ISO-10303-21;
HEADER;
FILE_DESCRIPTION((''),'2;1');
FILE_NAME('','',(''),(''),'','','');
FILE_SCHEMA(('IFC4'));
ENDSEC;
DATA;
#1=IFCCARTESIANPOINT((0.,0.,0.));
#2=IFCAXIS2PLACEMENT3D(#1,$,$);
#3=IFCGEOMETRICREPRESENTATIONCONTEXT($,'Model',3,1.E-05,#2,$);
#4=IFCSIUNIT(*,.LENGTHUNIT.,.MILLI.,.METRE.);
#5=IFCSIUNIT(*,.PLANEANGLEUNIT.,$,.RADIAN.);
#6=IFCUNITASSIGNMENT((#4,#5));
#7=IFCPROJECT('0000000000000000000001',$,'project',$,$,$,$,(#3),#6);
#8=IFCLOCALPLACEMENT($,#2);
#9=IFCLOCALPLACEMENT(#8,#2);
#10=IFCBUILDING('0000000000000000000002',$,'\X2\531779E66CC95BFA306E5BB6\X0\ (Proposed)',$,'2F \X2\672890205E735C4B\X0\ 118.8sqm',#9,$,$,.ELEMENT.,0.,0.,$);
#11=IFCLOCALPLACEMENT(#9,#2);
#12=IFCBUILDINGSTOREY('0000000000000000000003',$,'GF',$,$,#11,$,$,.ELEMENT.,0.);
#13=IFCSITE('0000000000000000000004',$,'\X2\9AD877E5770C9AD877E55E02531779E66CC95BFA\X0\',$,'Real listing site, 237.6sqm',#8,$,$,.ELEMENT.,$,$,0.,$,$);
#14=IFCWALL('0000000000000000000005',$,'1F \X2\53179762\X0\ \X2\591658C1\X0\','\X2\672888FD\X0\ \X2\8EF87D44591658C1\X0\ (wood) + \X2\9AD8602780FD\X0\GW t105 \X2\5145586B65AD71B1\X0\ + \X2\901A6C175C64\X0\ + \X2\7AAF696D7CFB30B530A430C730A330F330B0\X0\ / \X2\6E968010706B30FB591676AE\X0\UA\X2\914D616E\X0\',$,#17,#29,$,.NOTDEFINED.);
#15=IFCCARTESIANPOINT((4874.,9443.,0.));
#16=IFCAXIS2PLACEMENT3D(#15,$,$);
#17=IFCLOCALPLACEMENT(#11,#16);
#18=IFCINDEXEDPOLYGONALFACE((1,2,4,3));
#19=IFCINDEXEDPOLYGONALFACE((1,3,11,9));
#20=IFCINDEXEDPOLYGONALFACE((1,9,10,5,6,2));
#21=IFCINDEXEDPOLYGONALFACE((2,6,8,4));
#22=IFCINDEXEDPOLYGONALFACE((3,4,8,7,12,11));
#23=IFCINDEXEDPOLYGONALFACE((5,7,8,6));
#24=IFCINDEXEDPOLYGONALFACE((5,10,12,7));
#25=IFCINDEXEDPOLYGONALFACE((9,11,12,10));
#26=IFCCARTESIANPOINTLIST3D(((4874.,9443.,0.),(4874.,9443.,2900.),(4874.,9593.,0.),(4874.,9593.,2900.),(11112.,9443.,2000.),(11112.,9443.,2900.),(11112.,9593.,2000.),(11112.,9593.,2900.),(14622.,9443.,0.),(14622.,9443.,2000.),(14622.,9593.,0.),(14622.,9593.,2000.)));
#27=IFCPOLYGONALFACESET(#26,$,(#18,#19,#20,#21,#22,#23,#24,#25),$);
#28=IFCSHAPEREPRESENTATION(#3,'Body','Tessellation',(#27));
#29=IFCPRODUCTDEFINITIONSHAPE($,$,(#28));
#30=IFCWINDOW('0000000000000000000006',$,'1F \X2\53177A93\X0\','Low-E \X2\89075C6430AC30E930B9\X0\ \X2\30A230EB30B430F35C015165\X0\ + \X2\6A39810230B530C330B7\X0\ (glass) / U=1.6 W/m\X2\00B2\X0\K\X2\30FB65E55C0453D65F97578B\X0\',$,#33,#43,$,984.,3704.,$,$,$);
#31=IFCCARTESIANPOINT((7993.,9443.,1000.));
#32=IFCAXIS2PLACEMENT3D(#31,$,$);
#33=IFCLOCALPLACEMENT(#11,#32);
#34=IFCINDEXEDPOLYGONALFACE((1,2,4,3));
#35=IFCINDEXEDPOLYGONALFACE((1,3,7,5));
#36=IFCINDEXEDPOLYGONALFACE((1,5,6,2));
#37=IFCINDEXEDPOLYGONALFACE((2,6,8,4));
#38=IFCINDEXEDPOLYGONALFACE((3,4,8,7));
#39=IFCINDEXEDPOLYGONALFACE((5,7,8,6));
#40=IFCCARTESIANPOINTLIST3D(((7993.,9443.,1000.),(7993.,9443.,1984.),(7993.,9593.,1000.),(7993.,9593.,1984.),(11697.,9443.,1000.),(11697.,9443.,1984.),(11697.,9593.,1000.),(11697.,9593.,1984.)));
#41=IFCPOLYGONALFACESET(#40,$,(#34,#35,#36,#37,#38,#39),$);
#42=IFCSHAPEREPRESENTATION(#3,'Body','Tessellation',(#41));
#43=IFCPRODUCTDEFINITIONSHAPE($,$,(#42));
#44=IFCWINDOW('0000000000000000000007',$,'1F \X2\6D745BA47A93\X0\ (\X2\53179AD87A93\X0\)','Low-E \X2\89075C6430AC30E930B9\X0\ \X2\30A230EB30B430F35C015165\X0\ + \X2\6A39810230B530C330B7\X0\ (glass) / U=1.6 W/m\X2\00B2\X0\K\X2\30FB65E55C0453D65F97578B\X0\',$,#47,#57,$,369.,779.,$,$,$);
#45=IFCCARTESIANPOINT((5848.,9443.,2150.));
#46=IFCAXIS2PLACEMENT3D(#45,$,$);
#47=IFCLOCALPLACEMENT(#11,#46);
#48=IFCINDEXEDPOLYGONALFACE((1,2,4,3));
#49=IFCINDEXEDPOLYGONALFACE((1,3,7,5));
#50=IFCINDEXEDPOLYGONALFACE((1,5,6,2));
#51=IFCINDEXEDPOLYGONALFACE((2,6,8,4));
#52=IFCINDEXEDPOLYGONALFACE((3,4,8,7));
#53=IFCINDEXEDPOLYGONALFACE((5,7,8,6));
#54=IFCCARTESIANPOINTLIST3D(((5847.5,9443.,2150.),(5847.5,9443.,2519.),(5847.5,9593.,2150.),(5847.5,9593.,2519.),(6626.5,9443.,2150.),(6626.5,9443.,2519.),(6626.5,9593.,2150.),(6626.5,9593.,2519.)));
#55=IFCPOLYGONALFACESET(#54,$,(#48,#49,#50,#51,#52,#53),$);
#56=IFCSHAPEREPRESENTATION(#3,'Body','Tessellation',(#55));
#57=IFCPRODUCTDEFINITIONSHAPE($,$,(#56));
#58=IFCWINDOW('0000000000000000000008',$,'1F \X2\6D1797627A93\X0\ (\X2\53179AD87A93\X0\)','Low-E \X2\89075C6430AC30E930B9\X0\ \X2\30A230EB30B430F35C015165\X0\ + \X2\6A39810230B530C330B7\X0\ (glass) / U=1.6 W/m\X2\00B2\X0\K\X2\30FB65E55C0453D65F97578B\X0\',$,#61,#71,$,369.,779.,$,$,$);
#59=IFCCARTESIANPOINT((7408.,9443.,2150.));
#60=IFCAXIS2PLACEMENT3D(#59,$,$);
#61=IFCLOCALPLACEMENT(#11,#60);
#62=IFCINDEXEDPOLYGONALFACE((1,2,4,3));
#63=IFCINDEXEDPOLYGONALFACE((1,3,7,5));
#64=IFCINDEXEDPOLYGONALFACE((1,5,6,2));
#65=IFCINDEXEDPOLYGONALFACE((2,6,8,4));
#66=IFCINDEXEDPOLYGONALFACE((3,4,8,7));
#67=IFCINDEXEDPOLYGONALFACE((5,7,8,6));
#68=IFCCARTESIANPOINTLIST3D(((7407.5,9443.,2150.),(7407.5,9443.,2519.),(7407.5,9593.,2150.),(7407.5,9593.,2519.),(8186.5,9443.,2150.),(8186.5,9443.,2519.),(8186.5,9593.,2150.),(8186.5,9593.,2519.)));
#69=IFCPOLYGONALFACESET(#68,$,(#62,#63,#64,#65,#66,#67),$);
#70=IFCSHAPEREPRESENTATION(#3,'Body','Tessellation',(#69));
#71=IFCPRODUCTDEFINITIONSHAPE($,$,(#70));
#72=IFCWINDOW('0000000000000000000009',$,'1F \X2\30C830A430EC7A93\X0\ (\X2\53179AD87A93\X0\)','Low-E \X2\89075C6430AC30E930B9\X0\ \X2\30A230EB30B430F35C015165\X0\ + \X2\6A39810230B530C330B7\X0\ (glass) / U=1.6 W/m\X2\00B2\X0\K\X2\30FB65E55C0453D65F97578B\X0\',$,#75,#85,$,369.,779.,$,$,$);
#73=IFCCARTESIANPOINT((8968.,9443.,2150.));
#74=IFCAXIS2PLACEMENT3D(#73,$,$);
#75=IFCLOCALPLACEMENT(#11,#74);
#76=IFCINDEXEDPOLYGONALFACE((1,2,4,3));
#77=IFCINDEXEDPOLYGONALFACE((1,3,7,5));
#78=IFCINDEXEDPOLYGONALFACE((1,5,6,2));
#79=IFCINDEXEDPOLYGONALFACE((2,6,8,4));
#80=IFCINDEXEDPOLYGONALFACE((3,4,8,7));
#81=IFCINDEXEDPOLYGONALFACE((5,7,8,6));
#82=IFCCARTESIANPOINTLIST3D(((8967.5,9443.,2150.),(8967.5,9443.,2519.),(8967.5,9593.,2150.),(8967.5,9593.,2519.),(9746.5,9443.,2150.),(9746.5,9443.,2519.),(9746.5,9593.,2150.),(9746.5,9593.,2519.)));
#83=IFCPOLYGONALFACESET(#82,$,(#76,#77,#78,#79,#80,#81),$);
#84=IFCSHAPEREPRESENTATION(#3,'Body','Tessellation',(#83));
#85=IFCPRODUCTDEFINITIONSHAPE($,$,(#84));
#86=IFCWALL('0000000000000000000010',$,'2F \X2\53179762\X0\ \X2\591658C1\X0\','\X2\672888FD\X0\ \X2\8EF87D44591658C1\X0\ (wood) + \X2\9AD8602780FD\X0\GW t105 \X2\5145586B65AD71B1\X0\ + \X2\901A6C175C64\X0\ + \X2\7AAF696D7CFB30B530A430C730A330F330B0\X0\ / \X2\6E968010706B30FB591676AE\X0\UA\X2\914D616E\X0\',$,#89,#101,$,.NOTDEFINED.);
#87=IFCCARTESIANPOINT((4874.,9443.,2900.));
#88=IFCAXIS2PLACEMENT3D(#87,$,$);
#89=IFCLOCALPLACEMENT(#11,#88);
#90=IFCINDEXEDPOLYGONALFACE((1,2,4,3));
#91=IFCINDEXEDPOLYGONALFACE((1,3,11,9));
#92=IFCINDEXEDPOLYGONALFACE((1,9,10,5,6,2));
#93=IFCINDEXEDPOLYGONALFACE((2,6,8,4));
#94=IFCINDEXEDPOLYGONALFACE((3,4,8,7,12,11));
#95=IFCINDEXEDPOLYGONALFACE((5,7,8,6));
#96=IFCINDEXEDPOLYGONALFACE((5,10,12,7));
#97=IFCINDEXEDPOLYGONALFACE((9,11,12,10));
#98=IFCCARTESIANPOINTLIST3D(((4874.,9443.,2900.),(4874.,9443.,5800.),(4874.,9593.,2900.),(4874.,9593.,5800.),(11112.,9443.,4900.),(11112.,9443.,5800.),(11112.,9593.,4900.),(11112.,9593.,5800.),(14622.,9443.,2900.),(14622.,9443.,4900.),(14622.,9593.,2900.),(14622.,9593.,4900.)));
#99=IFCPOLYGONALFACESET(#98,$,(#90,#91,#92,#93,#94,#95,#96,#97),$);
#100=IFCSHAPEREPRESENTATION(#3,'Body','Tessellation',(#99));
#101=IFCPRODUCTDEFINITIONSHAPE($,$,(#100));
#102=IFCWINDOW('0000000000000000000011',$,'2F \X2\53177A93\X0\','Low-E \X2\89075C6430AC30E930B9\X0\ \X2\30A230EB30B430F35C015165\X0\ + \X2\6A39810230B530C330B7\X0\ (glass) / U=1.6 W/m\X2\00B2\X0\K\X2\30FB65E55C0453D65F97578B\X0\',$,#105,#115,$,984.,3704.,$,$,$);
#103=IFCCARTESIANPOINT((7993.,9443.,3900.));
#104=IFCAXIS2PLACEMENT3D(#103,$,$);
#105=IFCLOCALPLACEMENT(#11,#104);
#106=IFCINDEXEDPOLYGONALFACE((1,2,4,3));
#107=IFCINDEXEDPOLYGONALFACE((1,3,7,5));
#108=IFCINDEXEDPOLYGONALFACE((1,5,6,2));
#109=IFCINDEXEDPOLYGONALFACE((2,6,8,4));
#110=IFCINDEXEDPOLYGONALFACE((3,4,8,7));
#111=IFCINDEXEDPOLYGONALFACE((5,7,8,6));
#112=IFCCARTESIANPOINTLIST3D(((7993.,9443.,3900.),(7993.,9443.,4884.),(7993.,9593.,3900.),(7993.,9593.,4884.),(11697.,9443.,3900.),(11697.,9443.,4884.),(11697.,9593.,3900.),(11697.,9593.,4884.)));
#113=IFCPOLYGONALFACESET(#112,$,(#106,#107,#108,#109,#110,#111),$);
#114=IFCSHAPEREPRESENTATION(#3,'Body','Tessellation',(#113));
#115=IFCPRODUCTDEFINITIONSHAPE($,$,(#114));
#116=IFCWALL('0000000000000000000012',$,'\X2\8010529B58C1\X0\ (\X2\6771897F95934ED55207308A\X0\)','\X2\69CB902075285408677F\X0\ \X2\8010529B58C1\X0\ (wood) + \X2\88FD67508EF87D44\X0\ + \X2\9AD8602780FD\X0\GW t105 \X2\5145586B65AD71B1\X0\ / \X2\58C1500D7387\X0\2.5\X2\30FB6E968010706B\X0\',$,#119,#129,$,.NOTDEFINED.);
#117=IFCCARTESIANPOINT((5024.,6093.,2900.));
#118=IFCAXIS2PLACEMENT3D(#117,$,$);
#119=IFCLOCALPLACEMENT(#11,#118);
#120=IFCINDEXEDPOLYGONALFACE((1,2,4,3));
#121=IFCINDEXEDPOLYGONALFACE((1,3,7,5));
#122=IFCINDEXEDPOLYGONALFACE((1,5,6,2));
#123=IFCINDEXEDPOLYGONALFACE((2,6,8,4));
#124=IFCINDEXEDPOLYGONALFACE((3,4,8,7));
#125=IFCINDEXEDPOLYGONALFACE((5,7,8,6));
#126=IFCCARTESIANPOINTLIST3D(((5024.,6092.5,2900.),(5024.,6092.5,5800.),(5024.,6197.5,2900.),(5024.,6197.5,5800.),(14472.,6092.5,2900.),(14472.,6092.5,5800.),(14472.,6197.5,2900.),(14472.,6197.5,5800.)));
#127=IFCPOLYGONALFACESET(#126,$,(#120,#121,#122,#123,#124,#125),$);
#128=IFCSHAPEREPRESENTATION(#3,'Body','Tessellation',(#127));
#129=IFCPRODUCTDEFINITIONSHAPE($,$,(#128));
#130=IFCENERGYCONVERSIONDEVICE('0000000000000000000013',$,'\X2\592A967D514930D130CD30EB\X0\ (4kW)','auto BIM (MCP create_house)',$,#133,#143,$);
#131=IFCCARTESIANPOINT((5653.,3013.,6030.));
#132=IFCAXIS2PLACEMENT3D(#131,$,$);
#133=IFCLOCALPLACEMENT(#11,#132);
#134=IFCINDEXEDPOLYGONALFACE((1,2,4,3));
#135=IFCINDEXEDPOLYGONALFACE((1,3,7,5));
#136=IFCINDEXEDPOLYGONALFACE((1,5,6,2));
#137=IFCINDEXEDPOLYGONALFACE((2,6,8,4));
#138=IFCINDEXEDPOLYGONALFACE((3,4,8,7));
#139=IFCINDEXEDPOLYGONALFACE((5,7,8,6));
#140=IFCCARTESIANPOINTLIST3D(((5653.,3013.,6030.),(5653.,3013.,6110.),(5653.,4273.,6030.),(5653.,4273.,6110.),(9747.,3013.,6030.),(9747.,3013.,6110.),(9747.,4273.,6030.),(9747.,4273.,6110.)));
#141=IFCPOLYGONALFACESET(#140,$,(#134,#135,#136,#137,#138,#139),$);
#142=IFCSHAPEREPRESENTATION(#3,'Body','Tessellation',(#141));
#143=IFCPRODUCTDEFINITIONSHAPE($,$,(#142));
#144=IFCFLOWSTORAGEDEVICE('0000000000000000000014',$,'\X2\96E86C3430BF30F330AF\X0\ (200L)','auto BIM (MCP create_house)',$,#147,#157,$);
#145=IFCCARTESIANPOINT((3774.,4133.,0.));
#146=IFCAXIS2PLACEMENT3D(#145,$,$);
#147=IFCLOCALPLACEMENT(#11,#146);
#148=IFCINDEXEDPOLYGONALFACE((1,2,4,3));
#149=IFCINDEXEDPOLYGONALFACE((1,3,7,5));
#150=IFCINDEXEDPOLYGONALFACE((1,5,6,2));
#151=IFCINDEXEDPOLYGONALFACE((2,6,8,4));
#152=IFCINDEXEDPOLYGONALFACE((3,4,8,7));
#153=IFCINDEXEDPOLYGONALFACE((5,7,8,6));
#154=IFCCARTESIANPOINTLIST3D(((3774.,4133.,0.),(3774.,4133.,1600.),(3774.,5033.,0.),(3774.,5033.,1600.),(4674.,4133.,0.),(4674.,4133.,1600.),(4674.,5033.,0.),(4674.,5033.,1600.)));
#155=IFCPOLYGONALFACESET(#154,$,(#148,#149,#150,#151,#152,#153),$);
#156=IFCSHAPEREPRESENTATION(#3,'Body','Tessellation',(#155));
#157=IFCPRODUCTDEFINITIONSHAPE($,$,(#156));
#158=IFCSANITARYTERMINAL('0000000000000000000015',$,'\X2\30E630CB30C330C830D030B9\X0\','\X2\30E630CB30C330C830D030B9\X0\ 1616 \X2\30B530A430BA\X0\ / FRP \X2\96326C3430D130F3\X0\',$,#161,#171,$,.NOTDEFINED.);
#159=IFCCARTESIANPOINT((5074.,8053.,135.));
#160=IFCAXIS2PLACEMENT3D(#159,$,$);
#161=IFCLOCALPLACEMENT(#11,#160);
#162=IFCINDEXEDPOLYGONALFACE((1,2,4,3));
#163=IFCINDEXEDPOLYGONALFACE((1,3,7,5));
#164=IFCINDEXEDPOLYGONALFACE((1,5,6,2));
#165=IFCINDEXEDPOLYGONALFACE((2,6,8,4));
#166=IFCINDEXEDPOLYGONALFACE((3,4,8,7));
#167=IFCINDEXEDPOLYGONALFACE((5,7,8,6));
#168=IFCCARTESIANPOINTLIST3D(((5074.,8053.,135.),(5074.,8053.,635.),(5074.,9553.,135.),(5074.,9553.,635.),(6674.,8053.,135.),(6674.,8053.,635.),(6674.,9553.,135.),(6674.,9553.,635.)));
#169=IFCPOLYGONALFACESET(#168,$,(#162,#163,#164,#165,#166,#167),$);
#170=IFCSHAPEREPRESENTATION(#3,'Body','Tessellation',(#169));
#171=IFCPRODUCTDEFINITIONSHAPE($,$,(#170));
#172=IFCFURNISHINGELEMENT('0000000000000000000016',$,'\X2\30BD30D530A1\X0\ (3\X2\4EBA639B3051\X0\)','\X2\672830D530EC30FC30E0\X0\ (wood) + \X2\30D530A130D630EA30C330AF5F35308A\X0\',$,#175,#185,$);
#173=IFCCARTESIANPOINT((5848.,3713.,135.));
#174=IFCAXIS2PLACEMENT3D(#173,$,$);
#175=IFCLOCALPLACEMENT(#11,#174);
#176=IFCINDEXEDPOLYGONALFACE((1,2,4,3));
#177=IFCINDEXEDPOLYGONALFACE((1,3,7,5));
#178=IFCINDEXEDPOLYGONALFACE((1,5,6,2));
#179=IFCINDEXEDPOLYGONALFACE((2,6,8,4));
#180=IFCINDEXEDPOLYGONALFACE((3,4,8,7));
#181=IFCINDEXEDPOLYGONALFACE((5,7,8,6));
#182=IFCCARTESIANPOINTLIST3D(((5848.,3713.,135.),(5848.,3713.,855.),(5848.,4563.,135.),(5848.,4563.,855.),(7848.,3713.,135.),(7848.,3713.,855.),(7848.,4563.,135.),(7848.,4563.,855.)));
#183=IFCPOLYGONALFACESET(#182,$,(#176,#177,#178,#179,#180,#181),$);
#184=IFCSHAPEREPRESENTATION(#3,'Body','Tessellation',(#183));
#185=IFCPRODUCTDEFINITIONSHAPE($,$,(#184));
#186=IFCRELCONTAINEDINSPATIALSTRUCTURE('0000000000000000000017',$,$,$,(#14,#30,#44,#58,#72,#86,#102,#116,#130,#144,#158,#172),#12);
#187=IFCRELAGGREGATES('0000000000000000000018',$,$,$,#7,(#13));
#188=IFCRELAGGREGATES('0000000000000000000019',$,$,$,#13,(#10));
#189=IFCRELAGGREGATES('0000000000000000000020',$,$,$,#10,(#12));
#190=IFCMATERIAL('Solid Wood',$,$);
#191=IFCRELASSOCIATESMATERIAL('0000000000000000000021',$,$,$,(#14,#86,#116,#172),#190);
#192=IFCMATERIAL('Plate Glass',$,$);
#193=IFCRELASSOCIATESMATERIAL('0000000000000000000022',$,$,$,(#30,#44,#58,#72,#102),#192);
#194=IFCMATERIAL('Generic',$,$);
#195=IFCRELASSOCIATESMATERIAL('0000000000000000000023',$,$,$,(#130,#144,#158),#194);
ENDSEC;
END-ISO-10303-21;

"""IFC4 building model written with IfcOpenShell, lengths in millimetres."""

from ifc_helpers import new_model, si_unit, frame, frame_2d, origin, place, context, project, spatial, rectangle, extrude, material, element, fill, save


model = new_model("IFC4")

# Units and contexts
model_context = context("Model", 3, precision=1e-05, world=origin())
ifc_project = project(units=[si_unit("LENGTHUNIT", "METRE", prefix="MILLI"), si_unit("PLANEANGLEUNIT", "RADIAN")], contexts=[model_context])

# Site, building, storey
site_placement = place(None, origin())
site = spatial("IfcSite", under=ifc_project, at=site_placement, Name="高知県高知市北秦泉寺", ObjectType="Real listing site, 237.6sqm", CompositionType="ELEMENT", RefElevation=0.0)
building_placement = place(site_placement, origin())
building = spatial("IfcBuilding", under=site, at=building_placement, Name="北秦泉寺の家 (Proposed)", ObjectType="2F 木造平屋 118.8sqm", CompositionType="ELEMENT", ElevationOfRefHeight=0.0, ElevationOfTerrain=0.0)
storey_placement = place(building_placement, origin())
storey = spatial("IfcBuildingStorey", under=building, at=storey_placement, Name="GF", CompositionType="ELEMENT", Elevation=0.0)

# Wall, openings, windows
ifc_material_1 = material(Name="Solid Wood")
wall_1_placement = place(storey_placement, frame((4874.0, 9443.0, 0.0)))
wall_1 = element("IfcWall", 1, at=wall_1_placement, inside=storey, material=ifc_material_1, Name="1F 北面 外壁", Description="木製 軸組外壁 (wood) + 高性能GW t105 充填断熱 + 通気層 + 窯業系サイディング / 準耐火・外皮UA配慮", PredefinedType="NOTDEFINED", context=model_context, shape_type="SweptSolid", body=[
    extrude(rectangle(XDim=9748.0, YDim=150.0, at=frame_2d((4874.0, 75.0))), frame((4874.0, 9443.0, 0.0)), (0.0, 0.0, 1.0), 2900.0),
])
opening_1_placement = place(storey_placement, frame((7993.0, 9443.0, 1000.0)))
opening_1 = element("IfcOpeningElement", 2, at=opening_1_placement, cuts=wall_1, PredefinedType="NOTDEFINED", context=model_context, shape_type="SweptSolid", body=[
    extrude(rectangle(XDim=3704.0, YDim=150.0, at=frame_2d((1852.0, 75.0))), frame((7993.0, 9443.0, 1000.0)), (0.0, 0.0, 1.0), 984.0),
])
opening_2_placement = place(storey_placement, frame((5848.0, 9443.0, 2150.0)))
opening_2 = element("IfcOpeningElement", 3, at=opening_2_placement, cuts=wall_1, PredefinedType="NOTDEFINED", context=model_context, shape_type="SweptSolid", body=[
    extrude(rectangle(XDim=779.0, YDim=150.0, at=frame_2d((389.0, 75.0))), frame((5848.0, 9443.0, 2150.0)), (0.0, 0.0, 1.0), 369.0),
])
opening_3_placement = place(storey_placement, frame((7408.0, 9443.0, 2150.0)))
opening_3 = element("IfcOpeningElement", 4, at=opening_3_placement, cuts=wall_1, PredefinedType="NOTDEFINED", context=model_context, shape_type="SweptSolid", body=[
    extrude(rectangle(XDim=779.0, YDim=150.0, at=frame_2d((389.0, 75.0))), frame((7408.0, 9443.0, 2150.0)), (0.0, 0.0, 1.0), 369.0),
])
opening_4_placement = place(storey_placement, frame((8968.0, 9443.0, 2150.0)))
opening_4 = element("IfcOpeningElement", 5, at=opening_4_placement, cuts=wall_1, PredefinedType="NOTDEFINED", context=model_context, shape_type="SweptSolid", body=[
    extrude(rectangle(XDim=779.0, YDim=150.0, at=frame_2d((389.0, 75.0))), frame((8968.0, 9443.0, 2150.0)), (0.0, 0.0, 1.0), 369.0),
])
ifc_material_2 = material(Name="Plate Glass")
window_1_placement = place(storey_placement, frame((7993.0, 9443.0, 1000.0)))
window_1 = element("IfcWindow", 6, at=window_1_placement, inside=storey, material=ifc_material_2, Name="1F 北窓", Description="Low-E 複層ガラス アルゴン封入 + 樹脂サッシ (glass) / U=1.6 W/m²K・日射取得型", OverallHeight=984.0, OverallWidth=3704.0, context=model_context, shape_type="SweptSolid", body=[
    extrude(rectangle(XDim=3704.0, YDim=150.0, at=frame_2d((1852.0, 75.0))), frame((7993.0, 9443.0, 1000.0)), (0.0, 0.0, 1.0), 984.0),
])
fill(opening_1, window_1)
window_2_placement = place(storey_placement, frame((5848.0, 9443.0, 2150.0)))
window_2 = element("IfcWindow", 7, at=window_2_placement, inside=storey, material=ifc_material_2, Name="1F 浴室窓 (北高窓)", Description="Low-E 複層ガラス アルゴン封入 + 樹脂サッシ (glass) / U=1.6 W/m²K・日射取得型", OverallHeight=369.0, OverallWidth=779.0, context=model_context, shape_type="SweptSolid", body=[
    extrude(rectangle(XDim=779.0, YDim=150.0, at=frame_2d((389.0, 75.0))), frame((5848.0, 9443.0, 2150.0)), (0.0, 0.0, 1.0), 369.0),
])
fill(opening_2, window_2)
window_3_placement = place(storey_placement, frame((7408.0, 9443.0, 2150.0)))
window_3 = element("IfcWindow", 8, at=window_3_placement, inside=storey, material=ifc_material_2, Name="1F 洗面窓 (北高窓)", Description="Low-E 複層ガラス アルゴン封入 + 樹脂サッシ (glass) / U=1.6 W/m²K・日射取得型", OverallHeight=369.0, OverallWidth=779.0, context=model_context, shape_type="SweptSolid", body=[
    extrude(rectangle(XDim=779.0, YDim=150.0, at=frame_2d((389.0, 75.0))), frame((7408.0, 9443.0, 2150.0)), (0.0, 0.0, 1.0), 369.0),
])
fill(opening_3, window_3)
window_4_placement = place(storey_placement, frame((8968.0, 9443.0, 2150.0)))
window_4 = element("IfcWindow", 9, at=window_4_placement, inside=storey, material=ifc_material_2, Name="1F トイレ窓 (北高窓)", Description="Low-E 複層ガラス アルゴン封入 + 樹脂サッシ (glass) / U=1.6 W/m²K・日射取得型", OverallHeight=369.0, OverallWidth=779.0, context=model_context, shape_type="SweptSolid", body=[
    extrude(rectangle(XDim=779.0, YDim=150.0, at=frame_2d((389.0, 75.0))), frame((8968.0, 9443.0, 2150.0)), (0.0, 0.0, 1.0), 369.0),
])
fill(opening_4, window_4)

# Wall, opening, window
wall_2_placement = place(storey_placement, frame((4874.0, 9443.0, 2900.0)))
wall_2 = element("IfcWall", 10, at=wall_2_placement, inside=storey, material=ifc_material_1, Name="2F 北面 外壁", Description="木製 軸組外壁 (wood) + 高性能GW t105 充填断熱 + 通気層 + 窯業系サイディング / 準耐火・外皮UA配慮", PredefinedType="NOTDEFINED", context=model_context, shape_type="SweptSolid", body=[
    extrude(rectangle(XDim=9748.0, YDim=150.0, at=frame_2d((4874.0, 75.0))), frame((4874.0, 9443.0, 2900.0)), (0.0, 0.0, 1.0), 2900.0),
])
opening_5_placement = place(storey_placement, frame((7993.0, 9443.0, 3900.0)))
opening_5 = element("IfcOpeningElement", 11, at=opening_5_placement, cuts=wall_2, PredefinedType="NOTDEFINED", context=model_context, shape_type="SweptSolid", body=[
    extrude(rectangle(XDim=3704.0, YDim=150.0, at=frame_2d((1852.0, 75.0))), frame((7993.0, 9443.0, 3900.0)), (0.0, 0.0, 1.0), 984.0),
])
window_5_placement = place(storey_placement, frame((7993.0, 9443.0, 3900.0)))
window_5 = element("IfcWindow", 12, at=window_5_placement, inside=storey, material=ifc_material_2, Name="2F 北窓", Description="Low-E 複層ガラス アルゴン封入 + 樹脂サッシ (glass) / U=1.6 W/m²K・日射取得型", OverallHeight=984.0, OverallWidth=3704.0, context=model_context, shape_type="SweptSolid", body=[
    extrude(rectangle(XDim=3704.0, YDim=150.0, at=frame_2d((1852.0, 75.0))), frame((7993.0, 9443.0, 3900.0)), (0.0, 0.0, 1.0), 984.0),
])
fill(opening_5, window_5)

# Wall
wall_3_placement = place(storey_placement, frame((5024.0, 6093.0, 2900.0)))
element("IfcWall", 13, at=wall_3_placement, inside=storey, material=ifc_material_1, Name="耐力壁 (東西間仕切り)", Description="構造用合板 耐力壁 (wood) + 製材軸組 + 高性能GW t105 充填断熱 / 壁倍率2.5・準耐火", PredefinedType="NOTDEFINED", context=model_context, shape_type="SweptSolid", body=[
    extrude(rectangle(XDim=9448.0, YDim=105.0, at=frame_2d((4724.0, 52.0))), frame((5024.0, 6093.0, 2900.0)), (0.0, 0.0, 1.0), 2900.0),
])

# Energy conversion device
ifc_material_3 = material(Name="Generic")
energy_conversion_device_placement = place(storey_placement, frame((5653.0, 3013.0, 6030.0)))
element("IfcEnergyConversionDevice", 14, at=energy_conversion_device_placement, inside=storey, material=ifc_material_3, Name="太陽光パネル (4kW)", Description="auto BIM (MCP create_house)", context=model_context, shape_type="SweptSolid", body=[
    extrude(rectangle(XDim=4094.0, YDim=1260.0, at=frame_2d((2047.0, 630.0))), frame((5653.0, 3013.0, 6030.0)), (0.0, 0.0, 1.0), 80.0),
])

# Flow storage device
flow_storage_device_placement = place(storey_placement, frame((3774.0, 4133.0, 0.0)))
element("IfcFlowStorageDevice", 15, at=flow_storage_device_placement, inside=storey, material=ifc_material_3, Name="雨水タンク (200L)", Description="auto BIM (MCP create_house)", context=model_context, shape_type="SweptSolid", body=[
    extrude(rectangle(XDim=900.0, YDim=900.0, at=frame_2d((450.0, 450.0))), frame((3774.0, 4133.0, 0.0)), (0.0, 0.0, 1.0), 1600.0),
])

# Sanitary terminal
sanitary_terminal_placement = place(storey_placement, frame((5074.0, 8053.0, 135.0)))
element("IfcSanitaryTerminal", 16, at=sanitary_terminal_placement, inside=storey, material=ifc_material_3, Name="ユニットバス", Description="ユニットバス 1616 サイズ / FRP 防水パン", PredefinedType="NOTDEFINED", context=model_context, shape_type="SweptSolid", body=[
    extrude(rectangle(XDim=1600.0, YDim=1500.0, at=frame_2d((800.0, 750.0))), frame((5074.0, 8053.0, 135.0)), (0.0, 0.0, 1.0), 500.0),
])

# Furnishing element
furnishing_1_placement = place(storey_placement, frame((5848.0, 3713.0, 135.0)))
element("IfcFurnishingElement", 17, at=furnishing_1_placement, inside=storey, material=ifc_material_1, Name="ソファ (3人掛け)", Description="木フレーム (wood) + ファブリック張り", context=model_context, shape_type="SweptSolid", body=[
    extrude(rectangle(XDim=2000.0, YDim=850.0, at=frame_2d((1000.0, 425.0))), frame((5848.0, 3713.0, 135.0)), (0.0, 0.0, 1.0), 720.0),
])

save(model, "model.ifc")
